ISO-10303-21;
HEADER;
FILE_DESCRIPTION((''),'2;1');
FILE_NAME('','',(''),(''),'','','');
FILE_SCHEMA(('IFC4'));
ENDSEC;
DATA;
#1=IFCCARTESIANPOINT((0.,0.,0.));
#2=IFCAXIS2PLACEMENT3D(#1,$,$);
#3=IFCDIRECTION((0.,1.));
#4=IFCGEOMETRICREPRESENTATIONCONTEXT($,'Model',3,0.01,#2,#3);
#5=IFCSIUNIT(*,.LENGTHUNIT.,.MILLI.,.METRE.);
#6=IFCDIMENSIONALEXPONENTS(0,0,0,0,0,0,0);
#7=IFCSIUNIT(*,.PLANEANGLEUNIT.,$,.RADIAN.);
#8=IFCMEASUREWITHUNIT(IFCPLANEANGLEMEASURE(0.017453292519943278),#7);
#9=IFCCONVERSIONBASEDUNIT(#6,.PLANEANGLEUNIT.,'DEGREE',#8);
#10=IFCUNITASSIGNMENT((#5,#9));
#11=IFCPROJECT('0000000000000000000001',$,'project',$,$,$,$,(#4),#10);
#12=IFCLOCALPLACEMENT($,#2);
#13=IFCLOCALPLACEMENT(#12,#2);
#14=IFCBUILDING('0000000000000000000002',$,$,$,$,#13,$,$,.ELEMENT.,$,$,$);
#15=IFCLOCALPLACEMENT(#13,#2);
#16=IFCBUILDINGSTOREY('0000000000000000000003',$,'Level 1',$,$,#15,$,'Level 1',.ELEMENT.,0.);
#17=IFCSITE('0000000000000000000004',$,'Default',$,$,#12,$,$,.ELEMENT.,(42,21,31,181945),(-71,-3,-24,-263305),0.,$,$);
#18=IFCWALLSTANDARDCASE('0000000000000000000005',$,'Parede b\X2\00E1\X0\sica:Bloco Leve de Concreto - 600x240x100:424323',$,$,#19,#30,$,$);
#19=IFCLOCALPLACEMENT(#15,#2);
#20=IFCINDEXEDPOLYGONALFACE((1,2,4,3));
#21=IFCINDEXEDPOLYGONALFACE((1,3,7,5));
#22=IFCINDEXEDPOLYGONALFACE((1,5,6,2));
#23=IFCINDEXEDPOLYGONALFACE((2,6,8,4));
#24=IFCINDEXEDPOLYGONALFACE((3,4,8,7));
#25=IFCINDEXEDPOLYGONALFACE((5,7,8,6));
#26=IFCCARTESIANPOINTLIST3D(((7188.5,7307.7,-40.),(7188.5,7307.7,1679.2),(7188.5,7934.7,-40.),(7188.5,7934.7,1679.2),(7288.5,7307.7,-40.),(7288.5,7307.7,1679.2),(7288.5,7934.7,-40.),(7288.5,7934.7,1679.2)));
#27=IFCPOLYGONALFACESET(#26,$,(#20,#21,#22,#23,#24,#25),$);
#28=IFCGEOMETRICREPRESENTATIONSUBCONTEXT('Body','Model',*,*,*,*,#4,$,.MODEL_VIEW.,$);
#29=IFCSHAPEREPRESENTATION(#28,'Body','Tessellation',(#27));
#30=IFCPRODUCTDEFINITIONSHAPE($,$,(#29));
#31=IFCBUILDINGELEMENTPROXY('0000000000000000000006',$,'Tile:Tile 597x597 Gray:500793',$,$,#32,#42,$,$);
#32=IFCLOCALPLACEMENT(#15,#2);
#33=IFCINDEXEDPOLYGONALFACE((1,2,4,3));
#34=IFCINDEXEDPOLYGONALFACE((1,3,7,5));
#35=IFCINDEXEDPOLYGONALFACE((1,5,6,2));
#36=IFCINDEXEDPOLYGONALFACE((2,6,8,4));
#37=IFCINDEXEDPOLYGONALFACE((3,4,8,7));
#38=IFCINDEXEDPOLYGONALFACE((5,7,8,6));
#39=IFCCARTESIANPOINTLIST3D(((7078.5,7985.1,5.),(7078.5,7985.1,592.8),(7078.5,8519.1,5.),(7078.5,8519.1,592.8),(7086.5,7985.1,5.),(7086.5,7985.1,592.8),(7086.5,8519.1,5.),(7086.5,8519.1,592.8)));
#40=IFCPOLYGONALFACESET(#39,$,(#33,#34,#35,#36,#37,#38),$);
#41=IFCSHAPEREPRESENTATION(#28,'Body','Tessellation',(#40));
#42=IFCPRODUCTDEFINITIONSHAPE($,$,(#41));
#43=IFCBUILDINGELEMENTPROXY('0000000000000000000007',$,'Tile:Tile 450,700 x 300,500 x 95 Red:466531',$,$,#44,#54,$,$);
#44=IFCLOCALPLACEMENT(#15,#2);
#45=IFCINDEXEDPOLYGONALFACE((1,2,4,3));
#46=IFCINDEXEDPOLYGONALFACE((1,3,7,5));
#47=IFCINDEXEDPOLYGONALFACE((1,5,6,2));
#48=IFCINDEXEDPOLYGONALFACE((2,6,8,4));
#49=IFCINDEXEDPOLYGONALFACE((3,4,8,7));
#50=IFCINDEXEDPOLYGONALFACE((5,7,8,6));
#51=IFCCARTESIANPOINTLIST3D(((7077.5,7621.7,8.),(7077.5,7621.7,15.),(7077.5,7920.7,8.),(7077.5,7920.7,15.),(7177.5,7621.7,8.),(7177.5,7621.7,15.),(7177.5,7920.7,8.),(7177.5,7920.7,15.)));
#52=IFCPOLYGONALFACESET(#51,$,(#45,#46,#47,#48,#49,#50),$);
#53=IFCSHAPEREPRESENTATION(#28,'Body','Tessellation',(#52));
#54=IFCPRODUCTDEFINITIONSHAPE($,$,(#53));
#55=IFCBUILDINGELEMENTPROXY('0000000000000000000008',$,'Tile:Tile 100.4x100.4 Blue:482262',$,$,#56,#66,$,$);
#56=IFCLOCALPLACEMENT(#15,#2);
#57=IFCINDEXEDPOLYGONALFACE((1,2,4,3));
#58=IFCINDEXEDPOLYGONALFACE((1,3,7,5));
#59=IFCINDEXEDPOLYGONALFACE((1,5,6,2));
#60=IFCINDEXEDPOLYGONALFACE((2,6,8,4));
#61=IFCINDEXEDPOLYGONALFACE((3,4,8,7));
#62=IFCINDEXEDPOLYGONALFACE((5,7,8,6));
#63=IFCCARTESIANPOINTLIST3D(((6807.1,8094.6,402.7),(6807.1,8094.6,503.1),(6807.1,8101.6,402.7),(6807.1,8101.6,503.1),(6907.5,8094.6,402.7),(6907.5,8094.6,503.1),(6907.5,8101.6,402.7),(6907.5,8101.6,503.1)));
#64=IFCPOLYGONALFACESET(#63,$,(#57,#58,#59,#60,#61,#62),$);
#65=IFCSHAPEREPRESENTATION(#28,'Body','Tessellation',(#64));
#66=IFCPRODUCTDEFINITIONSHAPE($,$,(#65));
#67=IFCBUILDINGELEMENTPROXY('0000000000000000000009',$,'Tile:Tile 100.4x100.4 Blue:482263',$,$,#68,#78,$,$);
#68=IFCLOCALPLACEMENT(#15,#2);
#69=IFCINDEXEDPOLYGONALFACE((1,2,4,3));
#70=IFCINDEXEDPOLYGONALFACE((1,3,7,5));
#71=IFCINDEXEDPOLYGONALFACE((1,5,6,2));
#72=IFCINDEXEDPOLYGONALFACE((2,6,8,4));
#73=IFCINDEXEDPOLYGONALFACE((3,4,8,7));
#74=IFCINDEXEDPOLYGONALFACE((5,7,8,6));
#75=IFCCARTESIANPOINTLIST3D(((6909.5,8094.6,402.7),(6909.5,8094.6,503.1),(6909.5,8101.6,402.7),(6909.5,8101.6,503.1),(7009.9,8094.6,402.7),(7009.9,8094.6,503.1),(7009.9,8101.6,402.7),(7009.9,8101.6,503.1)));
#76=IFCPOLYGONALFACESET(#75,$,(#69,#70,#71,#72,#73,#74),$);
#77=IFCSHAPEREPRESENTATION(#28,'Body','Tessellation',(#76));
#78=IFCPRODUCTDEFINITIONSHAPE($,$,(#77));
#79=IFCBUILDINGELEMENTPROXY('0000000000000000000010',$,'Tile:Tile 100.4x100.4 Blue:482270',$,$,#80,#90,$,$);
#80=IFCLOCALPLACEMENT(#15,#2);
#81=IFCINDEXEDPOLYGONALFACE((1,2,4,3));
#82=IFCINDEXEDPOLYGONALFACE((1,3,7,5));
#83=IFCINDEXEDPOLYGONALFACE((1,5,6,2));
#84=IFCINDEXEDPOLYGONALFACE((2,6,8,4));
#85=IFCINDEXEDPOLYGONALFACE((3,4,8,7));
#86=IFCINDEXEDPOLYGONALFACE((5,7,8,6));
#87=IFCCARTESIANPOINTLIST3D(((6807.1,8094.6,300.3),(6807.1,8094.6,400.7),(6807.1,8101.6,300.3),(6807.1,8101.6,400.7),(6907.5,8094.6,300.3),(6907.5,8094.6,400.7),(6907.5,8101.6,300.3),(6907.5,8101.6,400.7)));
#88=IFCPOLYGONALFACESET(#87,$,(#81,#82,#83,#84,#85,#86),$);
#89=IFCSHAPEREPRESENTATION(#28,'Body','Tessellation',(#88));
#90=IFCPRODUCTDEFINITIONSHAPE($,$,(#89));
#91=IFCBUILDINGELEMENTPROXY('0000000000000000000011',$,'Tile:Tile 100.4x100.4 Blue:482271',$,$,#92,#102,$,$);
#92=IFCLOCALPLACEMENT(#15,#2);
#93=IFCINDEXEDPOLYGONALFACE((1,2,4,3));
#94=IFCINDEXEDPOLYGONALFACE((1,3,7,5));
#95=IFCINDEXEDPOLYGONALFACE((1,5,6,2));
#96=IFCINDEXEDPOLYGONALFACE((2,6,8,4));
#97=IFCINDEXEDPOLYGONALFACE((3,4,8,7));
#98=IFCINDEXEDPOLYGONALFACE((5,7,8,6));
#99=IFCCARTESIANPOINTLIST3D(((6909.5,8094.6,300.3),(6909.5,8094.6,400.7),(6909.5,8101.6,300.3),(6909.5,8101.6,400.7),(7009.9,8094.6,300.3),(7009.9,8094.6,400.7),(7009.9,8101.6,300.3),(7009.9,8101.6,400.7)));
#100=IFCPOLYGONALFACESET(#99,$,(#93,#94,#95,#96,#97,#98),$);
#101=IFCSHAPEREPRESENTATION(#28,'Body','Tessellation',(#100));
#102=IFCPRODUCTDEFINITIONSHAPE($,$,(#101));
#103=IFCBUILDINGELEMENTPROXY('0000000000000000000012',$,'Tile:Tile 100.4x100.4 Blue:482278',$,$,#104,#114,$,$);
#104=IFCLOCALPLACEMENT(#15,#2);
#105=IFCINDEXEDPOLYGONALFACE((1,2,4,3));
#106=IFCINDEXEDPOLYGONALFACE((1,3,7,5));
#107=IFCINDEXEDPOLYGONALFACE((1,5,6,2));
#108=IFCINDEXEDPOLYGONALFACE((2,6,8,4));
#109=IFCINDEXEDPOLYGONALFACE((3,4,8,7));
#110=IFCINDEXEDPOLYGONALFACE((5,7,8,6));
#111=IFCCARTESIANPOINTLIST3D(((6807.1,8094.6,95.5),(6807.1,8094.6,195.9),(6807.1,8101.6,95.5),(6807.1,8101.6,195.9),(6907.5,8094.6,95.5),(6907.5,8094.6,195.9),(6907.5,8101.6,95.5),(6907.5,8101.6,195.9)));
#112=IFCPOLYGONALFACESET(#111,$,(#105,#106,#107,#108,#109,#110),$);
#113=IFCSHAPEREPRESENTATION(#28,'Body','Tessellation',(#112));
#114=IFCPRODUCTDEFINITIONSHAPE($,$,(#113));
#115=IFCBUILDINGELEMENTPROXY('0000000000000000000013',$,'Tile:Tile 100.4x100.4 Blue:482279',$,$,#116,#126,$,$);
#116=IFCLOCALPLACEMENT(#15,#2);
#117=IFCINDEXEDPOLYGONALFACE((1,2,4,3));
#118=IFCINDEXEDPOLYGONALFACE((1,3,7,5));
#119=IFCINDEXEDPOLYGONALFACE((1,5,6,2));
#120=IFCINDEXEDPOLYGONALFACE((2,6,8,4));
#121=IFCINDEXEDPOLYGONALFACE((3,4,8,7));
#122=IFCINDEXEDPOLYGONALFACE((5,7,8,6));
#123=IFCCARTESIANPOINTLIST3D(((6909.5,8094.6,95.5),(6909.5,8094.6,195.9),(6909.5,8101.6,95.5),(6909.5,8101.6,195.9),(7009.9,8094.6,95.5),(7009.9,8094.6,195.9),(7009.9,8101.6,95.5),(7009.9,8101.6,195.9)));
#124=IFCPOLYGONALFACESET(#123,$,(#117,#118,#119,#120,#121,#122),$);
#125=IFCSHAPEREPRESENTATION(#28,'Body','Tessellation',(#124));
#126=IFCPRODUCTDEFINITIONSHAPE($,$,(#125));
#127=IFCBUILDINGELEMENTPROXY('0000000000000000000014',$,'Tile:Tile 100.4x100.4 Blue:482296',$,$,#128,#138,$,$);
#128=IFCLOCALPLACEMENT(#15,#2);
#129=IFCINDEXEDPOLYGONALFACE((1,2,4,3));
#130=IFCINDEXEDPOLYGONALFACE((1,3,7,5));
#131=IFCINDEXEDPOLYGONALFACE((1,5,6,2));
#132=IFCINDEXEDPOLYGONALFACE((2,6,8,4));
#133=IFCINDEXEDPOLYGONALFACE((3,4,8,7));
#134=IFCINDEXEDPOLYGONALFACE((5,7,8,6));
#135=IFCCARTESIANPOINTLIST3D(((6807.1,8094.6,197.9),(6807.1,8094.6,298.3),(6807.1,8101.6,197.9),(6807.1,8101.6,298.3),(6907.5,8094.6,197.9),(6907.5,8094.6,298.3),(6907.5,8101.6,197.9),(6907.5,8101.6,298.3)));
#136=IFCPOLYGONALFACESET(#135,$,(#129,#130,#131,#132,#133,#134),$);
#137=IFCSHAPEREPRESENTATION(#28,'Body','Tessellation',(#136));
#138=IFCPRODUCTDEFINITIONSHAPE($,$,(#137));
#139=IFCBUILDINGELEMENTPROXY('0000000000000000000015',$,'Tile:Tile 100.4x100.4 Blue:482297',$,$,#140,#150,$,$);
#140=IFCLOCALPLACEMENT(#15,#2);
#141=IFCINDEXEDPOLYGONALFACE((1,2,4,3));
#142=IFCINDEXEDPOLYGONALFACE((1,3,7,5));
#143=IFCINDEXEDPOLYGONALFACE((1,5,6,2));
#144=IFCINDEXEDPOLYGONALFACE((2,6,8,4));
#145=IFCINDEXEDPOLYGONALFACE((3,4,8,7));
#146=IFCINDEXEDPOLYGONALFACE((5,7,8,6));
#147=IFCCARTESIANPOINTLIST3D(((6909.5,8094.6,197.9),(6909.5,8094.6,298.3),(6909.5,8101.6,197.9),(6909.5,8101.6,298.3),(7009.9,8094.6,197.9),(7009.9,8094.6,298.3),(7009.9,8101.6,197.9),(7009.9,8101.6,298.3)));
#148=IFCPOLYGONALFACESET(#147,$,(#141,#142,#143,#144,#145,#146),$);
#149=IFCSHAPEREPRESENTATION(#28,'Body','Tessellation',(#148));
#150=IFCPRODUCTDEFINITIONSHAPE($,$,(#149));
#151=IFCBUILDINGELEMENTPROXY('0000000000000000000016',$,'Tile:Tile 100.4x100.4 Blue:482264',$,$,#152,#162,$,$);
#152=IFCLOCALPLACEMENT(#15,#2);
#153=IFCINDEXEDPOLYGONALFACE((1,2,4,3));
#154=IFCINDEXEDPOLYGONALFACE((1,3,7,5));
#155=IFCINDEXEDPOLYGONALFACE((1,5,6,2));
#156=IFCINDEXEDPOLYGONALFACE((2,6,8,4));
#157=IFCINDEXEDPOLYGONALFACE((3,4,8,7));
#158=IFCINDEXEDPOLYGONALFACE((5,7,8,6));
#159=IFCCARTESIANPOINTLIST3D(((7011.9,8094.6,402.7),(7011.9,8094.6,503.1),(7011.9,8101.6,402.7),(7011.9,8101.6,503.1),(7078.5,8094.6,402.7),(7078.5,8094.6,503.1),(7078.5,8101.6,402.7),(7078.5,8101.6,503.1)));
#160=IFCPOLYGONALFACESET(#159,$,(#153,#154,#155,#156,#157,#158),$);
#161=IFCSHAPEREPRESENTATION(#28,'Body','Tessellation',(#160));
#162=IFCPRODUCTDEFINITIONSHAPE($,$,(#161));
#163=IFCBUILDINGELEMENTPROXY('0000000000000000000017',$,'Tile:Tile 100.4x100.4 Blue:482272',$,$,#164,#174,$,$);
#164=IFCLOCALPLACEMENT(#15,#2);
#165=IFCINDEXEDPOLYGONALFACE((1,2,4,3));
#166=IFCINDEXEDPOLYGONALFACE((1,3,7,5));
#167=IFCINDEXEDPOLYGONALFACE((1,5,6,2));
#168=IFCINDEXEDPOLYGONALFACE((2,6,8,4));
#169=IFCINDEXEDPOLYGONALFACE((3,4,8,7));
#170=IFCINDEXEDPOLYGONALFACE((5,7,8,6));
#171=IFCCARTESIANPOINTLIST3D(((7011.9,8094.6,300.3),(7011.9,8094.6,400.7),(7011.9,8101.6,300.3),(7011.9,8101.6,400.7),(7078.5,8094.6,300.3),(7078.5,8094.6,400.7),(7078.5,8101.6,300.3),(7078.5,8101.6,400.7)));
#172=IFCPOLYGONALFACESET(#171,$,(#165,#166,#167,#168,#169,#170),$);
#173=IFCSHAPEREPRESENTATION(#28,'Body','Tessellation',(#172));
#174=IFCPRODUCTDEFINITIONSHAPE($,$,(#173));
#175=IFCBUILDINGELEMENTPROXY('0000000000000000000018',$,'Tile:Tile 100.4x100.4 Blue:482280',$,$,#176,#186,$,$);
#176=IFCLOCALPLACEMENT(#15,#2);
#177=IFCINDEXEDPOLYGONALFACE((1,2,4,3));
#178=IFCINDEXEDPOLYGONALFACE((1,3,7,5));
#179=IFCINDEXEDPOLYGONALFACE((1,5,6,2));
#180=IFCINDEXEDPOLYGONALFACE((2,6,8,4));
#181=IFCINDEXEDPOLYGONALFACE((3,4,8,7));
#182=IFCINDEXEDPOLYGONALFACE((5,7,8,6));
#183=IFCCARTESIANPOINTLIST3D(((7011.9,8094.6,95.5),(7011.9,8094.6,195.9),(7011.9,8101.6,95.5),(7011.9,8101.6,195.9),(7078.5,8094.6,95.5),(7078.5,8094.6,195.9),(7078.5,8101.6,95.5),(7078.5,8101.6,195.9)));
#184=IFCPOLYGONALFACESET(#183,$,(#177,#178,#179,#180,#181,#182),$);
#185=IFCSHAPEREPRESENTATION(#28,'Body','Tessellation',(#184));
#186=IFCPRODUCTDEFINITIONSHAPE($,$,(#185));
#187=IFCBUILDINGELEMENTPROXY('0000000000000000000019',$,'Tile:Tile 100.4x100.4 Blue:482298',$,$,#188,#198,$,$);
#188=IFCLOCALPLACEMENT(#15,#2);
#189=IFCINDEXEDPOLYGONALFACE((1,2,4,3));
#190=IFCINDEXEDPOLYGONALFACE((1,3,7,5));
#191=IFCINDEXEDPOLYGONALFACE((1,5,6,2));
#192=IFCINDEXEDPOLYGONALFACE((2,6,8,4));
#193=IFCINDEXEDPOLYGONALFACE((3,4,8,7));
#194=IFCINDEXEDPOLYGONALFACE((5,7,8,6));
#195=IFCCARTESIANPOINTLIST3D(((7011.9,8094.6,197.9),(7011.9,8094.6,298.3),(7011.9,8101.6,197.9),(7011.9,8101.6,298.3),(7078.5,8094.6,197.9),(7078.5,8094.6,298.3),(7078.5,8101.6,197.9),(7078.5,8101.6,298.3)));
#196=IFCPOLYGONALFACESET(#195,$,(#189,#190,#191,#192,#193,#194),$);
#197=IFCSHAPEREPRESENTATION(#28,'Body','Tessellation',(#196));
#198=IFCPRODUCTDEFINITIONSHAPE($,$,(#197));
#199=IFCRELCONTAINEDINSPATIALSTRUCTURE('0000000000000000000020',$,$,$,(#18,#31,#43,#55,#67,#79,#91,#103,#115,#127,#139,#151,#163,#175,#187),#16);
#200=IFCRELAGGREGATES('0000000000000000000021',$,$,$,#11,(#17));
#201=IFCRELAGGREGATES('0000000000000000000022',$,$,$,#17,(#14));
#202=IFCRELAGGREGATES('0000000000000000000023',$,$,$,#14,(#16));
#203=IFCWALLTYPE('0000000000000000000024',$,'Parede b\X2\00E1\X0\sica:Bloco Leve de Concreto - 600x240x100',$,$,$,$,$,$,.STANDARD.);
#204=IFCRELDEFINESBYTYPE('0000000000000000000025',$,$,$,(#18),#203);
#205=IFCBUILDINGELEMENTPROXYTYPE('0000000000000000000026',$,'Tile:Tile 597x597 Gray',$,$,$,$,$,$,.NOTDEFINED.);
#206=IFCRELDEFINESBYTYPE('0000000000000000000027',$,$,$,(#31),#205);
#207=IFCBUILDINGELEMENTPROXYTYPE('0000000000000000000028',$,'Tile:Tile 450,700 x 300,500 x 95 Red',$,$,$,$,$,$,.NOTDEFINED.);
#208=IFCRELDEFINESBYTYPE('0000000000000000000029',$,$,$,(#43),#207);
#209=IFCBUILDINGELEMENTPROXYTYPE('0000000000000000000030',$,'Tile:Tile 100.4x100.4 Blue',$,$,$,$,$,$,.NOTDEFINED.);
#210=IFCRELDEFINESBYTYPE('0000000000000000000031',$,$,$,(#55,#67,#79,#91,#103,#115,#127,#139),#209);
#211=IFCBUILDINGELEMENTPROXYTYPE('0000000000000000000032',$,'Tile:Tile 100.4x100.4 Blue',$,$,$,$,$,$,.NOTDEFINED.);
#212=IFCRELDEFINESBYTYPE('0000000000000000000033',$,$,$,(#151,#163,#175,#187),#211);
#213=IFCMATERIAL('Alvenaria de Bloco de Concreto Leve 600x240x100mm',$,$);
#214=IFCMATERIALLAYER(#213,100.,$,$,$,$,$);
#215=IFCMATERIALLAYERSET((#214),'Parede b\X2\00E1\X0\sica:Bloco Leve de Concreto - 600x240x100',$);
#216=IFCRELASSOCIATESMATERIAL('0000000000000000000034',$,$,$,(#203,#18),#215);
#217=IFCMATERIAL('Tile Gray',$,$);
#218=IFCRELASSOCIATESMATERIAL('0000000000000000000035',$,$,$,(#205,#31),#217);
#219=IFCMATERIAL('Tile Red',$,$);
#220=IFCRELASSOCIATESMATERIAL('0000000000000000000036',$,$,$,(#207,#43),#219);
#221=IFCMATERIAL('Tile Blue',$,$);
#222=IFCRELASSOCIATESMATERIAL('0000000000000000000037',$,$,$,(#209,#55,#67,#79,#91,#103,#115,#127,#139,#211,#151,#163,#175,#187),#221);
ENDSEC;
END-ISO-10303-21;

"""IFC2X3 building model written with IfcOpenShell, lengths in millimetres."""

from ifc_helpers import new_model, entity, si_unit, converted_unit, direction, frame, frame_2d, origin, origin_2d_with_axis, place, context, subcontext, project, spatial, rectangle, extrude, source, transform, mapped, material, layer, layer_set, layer_usage, type_object, type_shapes, element, save


model = new_model("IFC2X3")

# Units and contexts
model_context = context("Model", 3, precision=0.01, world=origin(), true_north=direction((0.0, 1.0)))
body_context = subcontext(model_context, "Body", "Model", "MODEL_VIEW")
ifc_project = project(units=[si_unit("LENGTHUNIT", "METRE", prefix="MILLI"), converted_unit("PLANEANGLEUNIT", "DEGREE", entity("IfcPlaneAngleMeasure", 0.017453292519943278), si_unit("PLANEANGLEUNIT", "RADIAN"), dimensions=[0, 0, 0, 0, 0, 0, 0])], contexts=[model_context])

# Site, building, storey
site_placement = place(None, origin())
site = spatial("IfcSite", under=ifc_project, at=site_placement, Name="Default", CompositionType="ELEMENT", RefLatitude=(42, 21, 31, 181945), RefLongitude=(-71, -3, -24, -263305), RefElevation=0.0)
building_placement = place(site_placement, origin())
building = spatial("IfcBuilding", under=site, at=building_placement, CompositionType="ELEMENT")
storey_placement = place(building_placement, origin())
storey = spatial("IfcBuildingStorey", under=building, at=storey_placement, Name="Level 1", LongName="Level 1", CompositionType="ELEMENT", Elevation=0.0)

# Wall
ifc_material_1 = material(Name="Alvenaria de Bloco de Concreto Leve 600x240x100mm")
ifc_layer = layer(ifc_material_1, 100.0)
ifc_layer_set = layer_set([ifc_layer], Name="Parede básica:Bloco Leve de Concreto - 600x240x100")
ifc_layer_usage = layer_usage(ifc_layer_set, "AXIS2", "NEGATIVE", 50.0)
wall_type = type_object("IfcWallType", Name="Parede básica:Bloco Leve de Concreto - 600x240x100", PredefinedType="STANDARD", material=ifc_layer_set)
wall_placement = place(storey_placement, frame((7238.5, 7934.7, -40.0), z_axis=(0.0, 0.0, 1.0), x_axis=(0.0, -1.0, 0.0)))
element("IfcWallStandardCase", 1, at=wall_placement, inside=storey, type_object=wall_type, material=ifc_layer_usage, Name="Parede básica:Bloco Leve de Concreto - 600x240x100:424323", context=body_context, shape_type="SweptSolid", body=[
    extrude(rectangle(XDim=627.0, YDim=100.0, at=frame_2d((313.5, 0.0), x_axis=(-1.0, 0.0))), origin(), (0.0, 0.0, 1.0), 1719.2),
])

# Building element proxies
ifc_material_2 = material(Name="Tile Gray")
building_element_proxy_type_1 = type_object("IfcBuildingElementProxyType", Name="Tile:Tile 597x597 Gray", PredefinedType="NOTDEFINED", material=ifc_material_2)
shared_shape_1 = source(origin(), body_context, "Body", "SweptSolid", [
    extrude(rectangle(XDim=534.0, YDim=587.8, at=frame_2d((0.0, 0.0), x_axis=(1.0, 0.0))), frame((-267.0, -293.9, 0.0), z_axis=(0.0, 0.0, 1.0), x_axis=(-1.0, 0.0, 0.0)), (0.0, 0.0, 1.0), 8.0),
])
type_shapes(building_element_proxy_type_1, [shared_shape_1])
proxy_1_placement = place(storey_placement, frame((7086.5, 7985.1, 592.8), z_axis=(-1.0, 0.0, 0.0), x_axis=(0.0, -1.0, 0.0)))
element("IfcBuildingElementProxy", 2, at=proxy_1_placement, inside=storey, type_object=building_element_proxy_type_1, material=ifc_material_2, Name="Tile:Tile 597x597 Gray:500793", context=body_context, shape_type="MappedRepresentation", body=[
    mapped(shared_shape_1, transform((0.0, 0.0, 0.0), scale=1.0)),
])
ifc_material_3 = material(Name="Tile Red")
building_element_proxy_type_2 = type_object("IfcBuildingElementProxyType", Name="Tile:Tile 450,700 x 300,500 x 95 Red", PredefinedType="NOTDEFINED", material=ifc_material_3)
shared_shape_2 = source(origin(), body_context, "Body", "SweptSolid", [
    extrude(rectangle(XDim=100.0, YDim=299.0, at=origin_2d_with_axis()), frame((-50.0, -149.5, 0.0), z_axis=(0.0, 0.0, 1.0), x_axis=(-1.0, 0.0, 0.0)), (0.0, 0.0, 1.0), 7.0),
])
type_shapes(building_element_proxy_type_2, [shared_shape_2])
proxy_2_placement = place(storey_placement, frame((7177.5, 7920.7, 8.0)))
element("IfcBuildingElementProxy", 3, at=proxy_2_placement, inside=storey, type_object=building_element_proxy_type_2, material=ifc_material_3, Name="Tile:Tile 450,700 x 300,500 x 95 Red:466531", context=body_context, shape_type="MappedRepresentation", body=[
    mapped(shared_shape_2, transform((0.0, 0.0, 0.0), scale=1.0)),
])
ifc_material_4 = material(Name="Tile Blue")
building_element_proxy_type_3 = type_object("IfcBuildingElementProxyType", Name="Tile:Tile 100.4x100.4 Blue", PredefinedType="NOTDEFINED", material=ifc_material_4)
shared_shape_3 = source(origin(), body_context, "Body", "SweptSolid", [
    extrude(rectangle(XDim=100.4, YDim=100.4, at=origin_2d_with_axis()), frame((-50.2, -50.2, 0.0), z_axis=(0.0, 0.0, 1.0), x_axis=(0.0, -1.0, 0.0)), (0.0, 0.0, 1.0), 7.0),
])
type_shapes(building_element_proxy_type_3, [shared_shape_3])
for number, where, z_axis, x_axis, name in (
    (4, (6807.1, 8101.6, 402.7), (0.0, -1.0, 0.0), (-1.0, 0.0, 0.0), "Tile:Tile 100.4x100.4 Blue:482262"),
    (5, (6909.5, 8101.6, 402.7), (0.0, -1.0, 0.0), (-1.0, 0.0, 0.0), "Tile:Tile 100.4x100.4 Blue:482263"),
    (6, (6807.1, 8101.6, 300.3), (0.0, -1.0, 0.0), (-1.0, 0.0, 0.0), "Tile:Tile 100.4x100.4 Blue:482270"),
    (7, (6909.5, 8101.6, 300.3), (0.0, -1.0, 0.0), (-1.0, 0.0, 0.0), "Tile:Tile 100.4x100.4 Blue:482271"),
    (8, (6807.1, 8101.6, 95.5), (0.0, -1.0, 0.0), (-1.0, 0.0, 0.0), "Tile:Tile 100.4x100.4 Blue:482278"),
    (9, (6909.5, 8101.6, 95.5), (0.0, -1.0, 0.0), (-1.0, 0.0, 0.0), "Tile:Tile 100.4x100.4 Blue:482279"),
    (10, (6807.1, 8101.6, 197.9), (0.0, -1.0, 0.0), (-1.0, 0.0, 0.0), "Tile:Tile 100.4x100.4 Blue:482296"),
    (11, (6909.5, 8101.6, 197.9), (0.0, -1.0, 0.0), (-1.0, 0.0, 0.0), "Tile:Tile 100.4x100.4 Blue:482297"),
):
    element("IfcBuildingElementProxy", number, at=place(storey_placement, frame(where, z_axis=z_axis, x_axis=x_axis)), inside=storey, type_object=building_element_proxy_type_3, material=ifc_material_4, Name=name, context=body_context, shape_type="MappedRepresentation", body=[
        mapped(shared_shape_3, transform((0.0, 0.0, 0.0), scale=1.0)),
    ])
building_element_proxy_type_4 = type_object("IfcBuildingElementProxyType", Name="Tile:Tile 100.4x100.4 Blue", PredefinedType="NOTDEFINED", material=ifc_material_4)
shared_shape_4 = source(origin(), body_context, "Body", "SweptSolid", [
    extrude(rectangle(XDim=66.6, YDim=100.4, at=origin_2d_with_axis()), frame((-33.3, -50.2, 0.0), z_axis=(0.0, 0.0, 1.0), x_axis=(-1.0, 0.0, 0.0)), (0.0, 0.0, 1.0), 7.0),
])
type_shapes(building_element_proxy_type_4, [shared_shape_4])
for number, where, z_axis, x_axis, name in (
    (12, (7011.9, 8101.6, 402.7), (0.0, -1.0, 0.0), (-1.0, 0.0, 0.0), "Tile:Tile 100.4x100.4 Blue:482264"),
    (13, (7011.9, 8101.6, 300.3), (0.0, -1.0, 0.0), (-1.0, 0.0, 0.0), "Tile:Tile 100.4x100.4 Blue:482272"),
    (14, (7011.9, 8101.6, 95.5), (0.0, -1.0, 0.0), (-1.0, 0.0, 0.0), "Tile:Tile 100.4x100.4 Blue:482280"),
    (15, (7011.9, 8101.6, 197.9), (0.0, -1.0, 0.0), (-1.0, 0.0, 0.0), "Tile:Tile 100.4x100.4 Blue:482298"),
):
    element("IfcBuildingElementProxy", number, at=place(storey_placement, frame(where, z_axis=z_axis, x_axis=x_axis)), inside=storey, type_object=building_element_proxy_type_4, material=ifc_material_4, Name=name, context=body_context, shape_type="MappedRepresentation", body=[
        mapped(shared_shape_4, transform((0.0, 0.0, 0.0), scale=1.0)),
    ])

save(model, "model.ifc")
